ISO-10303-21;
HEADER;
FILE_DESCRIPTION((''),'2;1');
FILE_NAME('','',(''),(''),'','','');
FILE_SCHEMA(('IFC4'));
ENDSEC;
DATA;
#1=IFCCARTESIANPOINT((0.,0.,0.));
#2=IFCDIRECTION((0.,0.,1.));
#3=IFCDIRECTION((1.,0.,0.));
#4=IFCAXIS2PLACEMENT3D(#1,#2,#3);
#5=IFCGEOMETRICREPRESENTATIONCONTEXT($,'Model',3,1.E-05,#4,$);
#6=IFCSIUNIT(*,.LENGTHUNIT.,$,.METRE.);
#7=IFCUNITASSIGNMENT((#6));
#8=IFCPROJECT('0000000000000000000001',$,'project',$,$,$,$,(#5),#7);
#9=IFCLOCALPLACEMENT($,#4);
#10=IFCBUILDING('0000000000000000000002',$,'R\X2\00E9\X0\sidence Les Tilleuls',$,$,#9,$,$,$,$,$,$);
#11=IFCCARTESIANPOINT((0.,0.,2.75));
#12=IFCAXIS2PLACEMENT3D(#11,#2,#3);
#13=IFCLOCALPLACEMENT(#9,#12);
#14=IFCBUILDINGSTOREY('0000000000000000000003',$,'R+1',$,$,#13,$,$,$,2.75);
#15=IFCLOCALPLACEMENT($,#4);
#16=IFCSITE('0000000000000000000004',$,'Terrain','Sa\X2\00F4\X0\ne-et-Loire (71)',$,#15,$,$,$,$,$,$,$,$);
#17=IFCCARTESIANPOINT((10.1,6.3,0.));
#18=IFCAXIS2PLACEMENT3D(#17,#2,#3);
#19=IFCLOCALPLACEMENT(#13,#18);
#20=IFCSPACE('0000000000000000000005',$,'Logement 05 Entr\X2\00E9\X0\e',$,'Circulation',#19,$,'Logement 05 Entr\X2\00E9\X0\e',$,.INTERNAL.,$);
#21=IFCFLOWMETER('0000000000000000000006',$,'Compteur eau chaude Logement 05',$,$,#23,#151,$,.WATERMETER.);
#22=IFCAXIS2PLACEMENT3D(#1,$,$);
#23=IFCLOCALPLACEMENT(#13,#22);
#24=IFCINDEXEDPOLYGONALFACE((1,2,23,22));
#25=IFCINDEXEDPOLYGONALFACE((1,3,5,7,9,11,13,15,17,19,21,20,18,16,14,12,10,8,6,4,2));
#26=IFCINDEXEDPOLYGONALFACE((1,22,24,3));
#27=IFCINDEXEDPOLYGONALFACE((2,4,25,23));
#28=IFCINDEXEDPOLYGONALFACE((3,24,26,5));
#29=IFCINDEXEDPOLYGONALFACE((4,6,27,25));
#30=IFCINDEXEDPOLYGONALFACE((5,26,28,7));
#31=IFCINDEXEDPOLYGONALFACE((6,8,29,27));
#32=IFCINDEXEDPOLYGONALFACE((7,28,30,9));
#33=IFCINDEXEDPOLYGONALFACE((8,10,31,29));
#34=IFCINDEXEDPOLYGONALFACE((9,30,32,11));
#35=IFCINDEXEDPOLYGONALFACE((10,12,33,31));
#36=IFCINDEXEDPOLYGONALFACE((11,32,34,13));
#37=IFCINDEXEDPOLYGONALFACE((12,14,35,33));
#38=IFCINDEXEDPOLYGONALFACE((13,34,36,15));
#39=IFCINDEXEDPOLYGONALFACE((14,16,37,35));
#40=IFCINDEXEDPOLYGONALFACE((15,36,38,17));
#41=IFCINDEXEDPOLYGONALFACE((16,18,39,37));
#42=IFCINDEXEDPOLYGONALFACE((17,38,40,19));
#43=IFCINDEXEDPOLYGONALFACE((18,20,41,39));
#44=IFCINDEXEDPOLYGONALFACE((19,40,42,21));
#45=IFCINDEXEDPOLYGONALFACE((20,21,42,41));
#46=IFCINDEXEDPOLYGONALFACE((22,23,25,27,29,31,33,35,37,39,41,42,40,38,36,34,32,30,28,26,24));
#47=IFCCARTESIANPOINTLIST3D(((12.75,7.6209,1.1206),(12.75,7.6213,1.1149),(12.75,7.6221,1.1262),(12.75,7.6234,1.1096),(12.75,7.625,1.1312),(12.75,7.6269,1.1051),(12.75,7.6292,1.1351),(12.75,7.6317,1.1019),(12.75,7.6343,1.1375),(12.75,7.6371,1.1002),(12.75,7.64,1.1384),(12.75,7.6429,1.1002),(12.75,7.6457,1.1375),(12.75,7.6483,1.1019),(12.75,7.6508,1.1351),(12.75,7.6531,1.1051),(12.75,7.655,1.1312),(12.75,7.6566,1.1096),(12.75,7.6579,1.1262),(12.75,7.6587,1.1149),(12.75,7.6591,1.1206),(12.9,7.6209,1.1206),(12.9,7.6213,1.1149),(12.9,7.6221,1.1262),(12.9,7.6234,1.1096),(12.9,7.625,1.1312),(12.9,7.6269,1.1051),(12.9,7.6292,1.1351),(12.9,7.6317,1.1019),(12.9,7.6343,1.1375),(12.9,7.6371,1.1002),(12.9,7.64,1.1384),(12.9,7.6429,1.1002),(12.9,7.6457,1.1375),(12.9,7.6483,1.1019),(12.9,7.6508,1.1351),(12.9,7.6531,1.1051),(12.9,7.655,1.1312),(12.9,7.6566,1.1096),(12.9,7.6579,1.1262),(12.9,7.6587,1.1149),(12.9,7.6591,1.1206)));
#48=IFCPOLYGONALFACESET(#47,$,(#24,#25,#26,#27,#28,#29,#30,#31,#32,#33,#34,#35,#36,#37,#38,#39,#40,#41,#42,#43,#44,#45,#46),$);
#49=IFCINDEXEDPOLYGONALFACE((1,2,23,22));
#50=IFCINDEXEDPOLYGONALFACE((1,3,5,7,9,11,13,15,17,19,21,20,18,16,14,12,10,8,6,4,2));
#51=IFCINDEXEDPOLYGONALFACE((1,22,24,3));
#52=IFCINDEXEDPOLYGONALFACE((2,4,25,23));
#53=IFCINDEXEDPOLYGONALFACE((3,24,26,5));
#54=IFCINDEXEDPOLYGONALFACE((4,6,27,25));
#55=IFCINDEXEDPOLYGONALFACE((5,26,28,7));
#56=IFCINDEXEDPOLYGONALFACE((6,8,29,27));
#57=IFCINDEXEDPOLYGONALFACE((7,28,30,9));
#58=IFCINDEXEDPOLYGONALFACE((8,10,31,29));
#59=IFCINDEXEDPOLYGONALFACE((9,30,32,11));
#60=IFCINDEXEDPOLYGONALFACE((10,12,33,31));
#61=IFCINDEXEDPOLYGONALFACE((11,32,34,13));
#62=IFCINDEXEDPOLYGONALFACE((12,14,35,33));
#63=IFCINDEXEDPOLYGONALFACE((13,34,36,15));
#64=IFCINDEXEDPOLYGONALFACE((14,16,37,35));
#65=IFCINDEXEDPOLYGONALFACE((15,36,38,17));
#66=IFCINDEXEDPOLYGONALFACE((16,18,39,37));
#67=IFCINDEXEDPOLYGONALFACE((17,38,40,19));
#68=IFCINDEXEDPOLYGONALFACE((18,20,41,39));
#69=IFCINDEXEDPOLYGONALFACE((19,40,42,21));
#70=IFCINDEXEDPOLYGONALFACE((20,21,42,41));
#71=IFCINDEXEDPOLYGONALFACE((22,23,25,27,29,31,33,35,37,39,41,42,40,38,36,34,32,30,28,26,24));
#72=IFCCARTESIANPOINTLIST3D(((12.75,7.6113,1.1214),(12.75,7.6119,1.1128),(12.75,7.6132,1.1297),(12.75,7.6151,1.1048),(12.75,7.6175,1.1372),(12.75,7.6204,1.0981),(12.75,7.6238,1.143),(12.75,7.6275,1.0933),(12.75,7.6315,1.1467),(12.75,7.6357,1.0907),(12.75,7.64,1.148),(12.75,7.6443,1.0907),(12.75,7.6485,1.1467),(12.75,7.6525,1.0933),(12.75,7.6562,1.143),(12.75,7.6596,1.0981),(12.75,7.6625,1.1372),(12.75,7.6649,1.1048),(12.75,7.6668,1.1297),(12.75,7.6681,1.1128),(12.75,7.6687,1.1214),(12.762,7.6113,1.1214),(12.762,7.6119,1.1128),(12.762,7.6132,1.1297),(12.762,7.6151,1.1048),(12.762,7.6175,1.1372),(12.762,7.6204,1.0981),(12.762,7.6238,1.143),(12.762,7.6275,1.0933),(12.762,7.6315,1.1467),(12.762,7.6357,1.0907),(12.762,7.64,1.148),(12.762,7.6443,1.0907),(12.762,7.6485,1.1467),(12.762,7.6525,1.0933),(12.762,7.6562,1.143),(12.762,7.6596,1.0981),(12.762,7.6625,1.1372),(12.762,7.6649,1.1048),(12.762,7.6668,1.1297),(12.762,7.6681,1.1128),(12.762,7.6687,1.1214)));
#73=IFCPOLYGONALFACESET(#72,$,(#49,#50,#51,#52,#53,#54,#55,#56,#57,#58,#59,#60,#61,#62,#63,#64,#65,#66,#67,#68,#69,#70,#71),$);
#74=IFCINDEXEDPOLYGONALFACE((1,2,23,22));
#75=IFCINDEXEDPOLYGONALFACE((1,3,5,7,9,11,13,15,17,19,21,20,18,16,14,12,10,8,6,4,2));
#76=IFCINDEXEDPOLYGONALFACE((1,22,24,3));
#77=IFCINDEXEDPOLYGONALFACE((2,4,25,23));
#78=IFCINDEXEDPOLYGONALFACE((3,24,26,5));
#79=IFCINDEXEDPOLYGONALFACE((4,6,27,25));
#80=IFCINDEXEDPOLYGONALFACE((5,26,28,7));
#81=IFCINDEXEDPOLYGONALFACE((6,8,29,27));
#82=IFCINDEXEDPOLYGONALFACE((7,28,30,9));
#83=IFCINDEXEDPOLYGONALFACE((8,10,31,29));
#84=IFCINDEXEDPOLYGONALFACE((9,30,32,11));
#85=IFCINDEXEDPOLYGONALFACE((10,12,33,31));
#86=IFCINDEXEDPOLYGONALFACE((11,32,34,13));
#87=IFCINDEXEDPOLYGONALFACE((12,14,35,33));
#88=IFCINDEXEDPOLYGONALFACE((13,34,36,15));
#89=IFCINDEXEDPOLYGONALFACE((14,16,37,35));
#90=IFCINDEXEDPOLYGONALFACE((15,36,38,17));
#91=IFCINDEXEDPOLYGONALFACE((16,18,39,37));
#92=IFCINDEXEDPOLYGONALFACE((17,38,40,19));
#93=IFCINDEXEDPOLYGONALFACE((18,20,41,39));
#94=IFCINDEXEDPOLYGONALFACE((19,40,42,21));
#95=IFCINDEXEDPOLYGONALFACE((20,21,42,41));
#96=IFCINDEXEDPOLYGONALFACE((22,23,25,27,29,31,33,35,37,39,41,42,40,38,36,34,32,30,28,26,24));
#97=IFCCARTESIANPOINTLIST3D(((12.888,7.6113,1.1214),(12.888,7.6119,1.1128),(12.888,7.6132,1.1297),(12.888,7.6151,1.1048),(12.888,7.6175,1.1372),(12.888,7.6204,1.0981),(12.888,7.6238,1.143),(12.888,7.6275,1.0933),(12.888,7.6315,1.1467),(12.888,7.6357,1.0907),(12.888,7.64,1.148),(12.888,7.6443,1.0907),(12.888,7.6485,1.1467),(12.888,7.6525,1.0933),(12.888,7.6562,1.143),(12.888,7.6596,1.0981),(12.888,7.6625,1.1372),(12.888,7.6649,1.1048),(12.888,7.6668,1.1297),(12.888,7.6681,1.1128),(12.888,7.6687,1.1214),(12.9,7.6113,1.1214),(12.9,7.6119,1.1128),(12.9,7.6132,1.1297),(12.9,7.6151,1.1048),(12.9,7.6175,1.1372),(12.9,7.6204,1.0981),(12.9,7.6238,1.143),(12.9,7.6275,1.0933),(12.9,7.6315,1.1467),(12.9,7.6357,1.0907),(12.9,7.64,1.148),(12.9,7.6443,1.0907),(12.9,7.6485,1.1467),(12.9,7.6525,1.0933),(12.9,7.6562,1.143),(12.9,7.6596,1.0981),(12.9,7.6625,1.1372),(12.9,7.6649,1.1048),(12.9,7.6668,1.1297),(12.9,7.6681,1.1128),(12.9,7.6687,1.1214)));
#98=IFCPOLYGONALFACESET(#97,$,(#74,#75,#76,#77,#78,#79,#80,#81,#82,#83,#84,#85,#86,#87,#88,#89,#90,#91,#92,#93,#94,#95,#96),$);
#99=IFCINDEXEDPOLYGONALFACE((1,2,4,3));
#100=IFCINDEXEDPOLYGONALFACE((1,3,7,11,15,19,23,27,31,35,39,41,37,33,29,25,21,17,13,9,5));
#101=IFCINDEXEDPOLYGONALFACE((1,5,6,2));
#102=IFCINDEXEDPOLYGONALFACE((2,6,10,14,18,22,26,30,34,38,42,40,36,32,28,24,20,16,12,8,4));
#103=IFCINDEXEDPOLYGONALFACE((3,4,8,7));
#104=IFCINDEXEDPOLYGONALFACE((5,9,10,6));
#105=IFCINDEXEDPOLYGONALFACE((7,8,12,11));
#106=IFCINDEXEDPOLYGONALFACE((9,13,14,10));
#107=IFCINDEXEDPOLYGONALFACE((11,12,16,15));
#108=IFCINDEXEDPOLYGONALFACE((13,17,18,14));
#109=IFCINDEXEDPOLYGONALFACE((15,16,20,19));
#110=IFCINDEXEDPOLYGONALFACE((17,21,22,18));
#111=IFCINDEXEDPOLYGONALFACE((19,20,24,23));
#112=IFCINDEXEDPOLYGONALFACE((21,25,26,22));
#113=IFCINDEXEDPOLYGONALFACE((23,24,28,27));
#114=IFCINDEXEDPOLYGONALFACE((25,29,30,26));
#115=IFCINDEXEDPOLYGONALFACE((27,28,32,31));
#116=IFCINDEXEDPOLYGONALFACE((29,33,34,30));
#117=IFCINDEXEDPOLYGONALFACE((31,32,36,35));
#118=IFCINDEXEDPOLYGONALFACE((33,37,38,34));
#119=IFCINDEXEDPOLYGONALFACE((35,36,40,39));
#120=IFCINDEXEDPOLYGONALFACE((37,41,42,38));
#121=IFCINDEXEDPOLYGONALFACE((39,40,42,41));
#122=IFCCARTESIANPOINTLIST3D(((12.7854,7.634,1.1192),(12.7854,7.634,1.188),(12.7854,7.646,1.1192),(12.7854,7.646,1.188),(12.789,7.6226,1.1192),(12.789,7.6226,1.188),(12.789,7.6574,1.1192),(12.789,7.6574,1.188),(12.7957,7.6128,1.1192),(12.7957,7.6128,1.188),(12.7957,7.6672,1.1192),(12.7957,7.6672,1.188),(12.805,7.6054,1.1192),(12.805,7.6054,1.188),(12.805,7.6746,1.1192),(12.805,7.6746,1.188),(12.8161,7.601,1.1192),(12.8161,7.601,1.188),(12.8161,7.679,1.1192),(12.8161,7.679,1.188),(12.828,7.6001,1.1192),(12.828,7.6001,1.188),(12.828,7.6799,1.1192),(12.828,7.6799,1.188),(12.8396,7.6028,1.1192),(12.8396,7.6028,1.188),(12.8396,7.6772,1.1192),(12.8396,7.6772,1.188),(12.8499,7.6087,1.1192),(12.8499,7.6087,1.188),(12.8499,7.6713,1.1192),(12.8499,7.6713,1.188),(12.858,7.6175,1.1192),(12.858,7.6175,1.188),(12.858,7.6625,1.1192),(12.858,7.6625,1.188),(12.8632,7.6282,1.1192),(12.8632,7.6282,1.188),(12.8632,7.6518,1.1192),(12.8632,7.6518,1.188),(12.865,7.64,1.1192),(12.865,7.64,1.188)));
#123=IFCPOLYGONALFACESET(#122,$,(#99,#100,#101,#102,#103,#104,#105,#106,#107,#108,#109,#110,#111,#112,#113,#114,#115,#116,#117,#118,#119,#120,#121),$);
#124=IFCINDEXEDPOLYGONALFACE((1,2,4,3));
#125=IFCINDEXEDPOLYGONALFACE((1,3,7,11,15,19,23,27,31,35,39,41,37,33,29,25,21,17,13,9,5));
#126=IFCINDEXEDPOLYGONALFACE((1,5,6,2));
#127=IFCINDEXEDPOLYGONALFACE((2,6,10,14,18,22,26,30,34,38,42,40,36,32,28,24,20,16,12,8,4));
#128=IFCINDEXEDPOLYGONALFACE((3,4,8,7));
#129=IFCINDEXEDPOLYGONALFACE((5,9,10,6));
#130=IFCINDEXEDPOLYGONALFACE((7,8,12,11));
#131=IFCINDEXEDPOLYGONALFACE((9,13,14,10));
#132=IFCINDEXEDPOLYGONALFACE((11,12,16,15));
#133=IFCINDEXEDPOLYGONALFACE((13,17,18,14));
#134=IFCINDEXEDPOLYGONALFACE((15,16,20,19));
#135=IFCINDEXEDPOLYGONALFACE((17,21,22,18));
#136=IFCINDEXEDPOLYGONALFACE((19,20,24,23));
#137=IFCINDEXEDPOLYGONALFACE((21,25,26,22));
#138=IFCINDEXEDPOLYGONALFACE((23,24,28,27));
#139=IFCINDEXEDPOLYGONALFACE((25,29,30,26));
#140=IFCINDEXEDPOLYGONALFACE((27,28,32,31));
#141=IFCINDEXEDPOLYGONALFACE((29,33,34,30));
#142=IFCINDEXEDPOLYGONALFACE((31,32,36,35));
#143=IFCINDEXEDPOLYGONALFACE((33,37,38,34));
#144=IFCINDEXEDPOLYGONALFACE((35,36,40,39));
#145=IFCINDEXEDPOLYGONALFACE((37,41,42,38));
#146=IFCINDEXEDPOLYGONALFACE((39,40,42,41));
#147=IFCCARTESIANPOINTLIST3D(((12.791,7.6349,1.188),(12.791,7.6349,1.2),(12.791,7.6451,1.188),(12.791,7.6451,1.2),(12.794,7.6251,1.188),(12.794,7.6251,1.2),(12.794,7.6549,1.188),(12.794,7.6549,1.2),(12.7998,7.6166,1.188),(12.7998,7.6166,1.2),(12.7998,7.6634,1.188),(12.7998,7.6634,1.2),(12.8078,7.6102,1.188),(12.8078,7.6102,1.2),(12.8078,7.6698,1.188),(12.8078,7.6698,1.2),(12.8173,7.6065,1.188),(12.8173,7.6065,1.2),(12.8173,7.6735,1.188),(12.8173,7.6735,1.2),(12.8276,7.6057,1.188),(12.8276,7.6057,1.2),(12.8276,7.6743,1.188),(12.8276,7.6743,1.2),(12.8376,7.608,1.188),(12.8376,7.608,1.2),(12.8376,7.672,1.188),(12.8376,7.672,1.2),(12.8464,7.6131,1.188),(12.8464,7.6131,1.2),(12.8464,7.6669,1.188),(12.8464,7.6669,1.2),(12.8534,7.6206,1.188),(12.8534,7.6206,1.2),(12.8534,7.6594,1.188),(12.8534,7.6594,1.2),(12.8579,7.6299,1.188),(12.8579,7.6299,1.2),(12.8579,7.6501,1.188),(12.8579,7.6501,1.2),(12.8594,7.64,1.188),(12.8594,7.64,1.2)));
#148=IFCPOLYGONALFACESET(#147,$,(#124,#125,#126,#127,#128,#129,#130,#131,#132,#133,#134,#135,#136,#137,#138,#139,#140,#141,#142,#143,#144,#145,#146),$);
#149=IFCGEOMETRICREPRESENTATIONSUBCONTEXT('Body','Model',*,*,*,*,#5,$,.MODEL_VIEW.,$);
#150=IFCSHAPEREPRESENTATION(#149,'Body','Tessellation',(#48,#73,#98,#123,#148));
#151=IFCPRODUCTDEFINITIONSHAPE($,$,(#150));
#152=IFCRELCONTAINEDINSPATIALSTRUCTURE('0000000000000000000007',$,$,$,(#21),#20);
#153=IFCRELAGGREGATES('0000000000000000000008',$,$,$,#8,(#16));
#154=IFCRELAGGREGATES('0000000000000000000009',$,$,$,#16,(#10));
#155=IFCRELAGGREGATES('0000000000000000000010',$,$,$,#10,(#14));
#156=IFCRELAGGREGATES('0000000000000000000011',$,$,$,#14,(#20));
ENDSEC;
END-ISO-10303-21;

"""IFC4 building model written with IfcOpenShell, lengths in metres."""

from ifc_helpers import new_model, si_unit, frame, origin_with_axes, place, context, subcontext, project, spatial, circle, extrude, element, save


model = new_model("IFC4")

# Units and contexts
model_context = context("Model", 3, precision=1e-05, world=origin_with_axes())
body_context = subcontext(model_context, "Body", "Model", "MODEL_VIEW")
ifc_project = project(units=[si_unit("LENGTHUNIT", "METRE")], contexts=[model_context])

# Site, building, storey
site_placement = place(None, origin_with_axes())
site = spatial("IfcSite", under=ifc_project, at=site_placement, Name="Terrain", Description="Saône-et-Loire (71)")
building_placement = place(None, origin_with_axes())
building = spatial("IfcBuilding", under=site, at=building_placement, Name="Résidence Les Tilleuls")
storey_placement = place(building_placement, frame((0.0, 0.0, 2.75), z_axis=(0.0, 0.0, 1.0), x_axis=(1.0, 0.0, 0.0)))
storey = spatial("IfcBuildingStorey", under=building, at=storey_placement, Name="R+1", Elevation=2.75)

# Shared definitions
space_1_placement = place(storey_placement, frame((10.1, 6.3, 0.0), z_axis=(0.0, 0.0, 1.0), x_axis=(1.0, 0.0, 0.0)))
space_1 = spatial("IfcSpace", under=storey, at=space_1_placement, Name="Logement 05 Entrée", ObjectType="Circulation", LongName="Logement 05 Entrée", PredefinedType="INTERNAL")

# Flow meter
for number, where, z_axis, x_axis, name in (
    (1, (2.65, 1.3, 1.1), (0.0, 0.0, 1.0), (1.0, 0.0, 0.0), "Compteur eau chaude Logement 05"),
):
    element("IfcFlowMeter", number, at=place(space_1_placement, frame(where, z_axis=z_axis, x_axis=x_axis)), inside=space_1, Name=name, PredefinedType="WATERMETER", context=body_context, shape_type="SweptSolid", body=[
        extrude(circle(Radius=0.0192), frame((0.0, 0.04, 0.0192), z_axis=(1.0, 0.0, 0.0), x_axis=(0.0, 0.0, 1.0)), (0.0, 0.0, 1.0), 0.15),
        extrude(circle(Radius=0.0288), frame((0.0, 0.04, 0.0192), z_axis=(1.0, 0.0, 0.0), x_axis=(0.0, 0.0, 1.0)), (0.0, 0.0, 1.0), 0.012),
        extrude(circle(Radius=0.0288), frame((0.138, 0.04, 0.0192), z_axis=(1.0, 0.0, 0.0), x_axis=(0.0, 0.0, 1.0)), (0.0, 0.0, 1.0), 0.012),
        extrude(circle(Radius=0.04), frame((0.075, 0.04, 0.0192), z_axis=(0.0, 0.0, 1.0), x_axis=(1.0, 0.0, 0.0)), (0.0, 0.0, 1.0), 0.0688),
        extrude(circle(Radius=0.0344), frame((0.075, 0.04, 0.088), z_axis=(0.0, 0.0, 1.0), x_axis=(1.0, 0.0, 0.0)), (0.0, 0.0, 1.0), 0.012),
    ])

save(model, "model.ifc")
